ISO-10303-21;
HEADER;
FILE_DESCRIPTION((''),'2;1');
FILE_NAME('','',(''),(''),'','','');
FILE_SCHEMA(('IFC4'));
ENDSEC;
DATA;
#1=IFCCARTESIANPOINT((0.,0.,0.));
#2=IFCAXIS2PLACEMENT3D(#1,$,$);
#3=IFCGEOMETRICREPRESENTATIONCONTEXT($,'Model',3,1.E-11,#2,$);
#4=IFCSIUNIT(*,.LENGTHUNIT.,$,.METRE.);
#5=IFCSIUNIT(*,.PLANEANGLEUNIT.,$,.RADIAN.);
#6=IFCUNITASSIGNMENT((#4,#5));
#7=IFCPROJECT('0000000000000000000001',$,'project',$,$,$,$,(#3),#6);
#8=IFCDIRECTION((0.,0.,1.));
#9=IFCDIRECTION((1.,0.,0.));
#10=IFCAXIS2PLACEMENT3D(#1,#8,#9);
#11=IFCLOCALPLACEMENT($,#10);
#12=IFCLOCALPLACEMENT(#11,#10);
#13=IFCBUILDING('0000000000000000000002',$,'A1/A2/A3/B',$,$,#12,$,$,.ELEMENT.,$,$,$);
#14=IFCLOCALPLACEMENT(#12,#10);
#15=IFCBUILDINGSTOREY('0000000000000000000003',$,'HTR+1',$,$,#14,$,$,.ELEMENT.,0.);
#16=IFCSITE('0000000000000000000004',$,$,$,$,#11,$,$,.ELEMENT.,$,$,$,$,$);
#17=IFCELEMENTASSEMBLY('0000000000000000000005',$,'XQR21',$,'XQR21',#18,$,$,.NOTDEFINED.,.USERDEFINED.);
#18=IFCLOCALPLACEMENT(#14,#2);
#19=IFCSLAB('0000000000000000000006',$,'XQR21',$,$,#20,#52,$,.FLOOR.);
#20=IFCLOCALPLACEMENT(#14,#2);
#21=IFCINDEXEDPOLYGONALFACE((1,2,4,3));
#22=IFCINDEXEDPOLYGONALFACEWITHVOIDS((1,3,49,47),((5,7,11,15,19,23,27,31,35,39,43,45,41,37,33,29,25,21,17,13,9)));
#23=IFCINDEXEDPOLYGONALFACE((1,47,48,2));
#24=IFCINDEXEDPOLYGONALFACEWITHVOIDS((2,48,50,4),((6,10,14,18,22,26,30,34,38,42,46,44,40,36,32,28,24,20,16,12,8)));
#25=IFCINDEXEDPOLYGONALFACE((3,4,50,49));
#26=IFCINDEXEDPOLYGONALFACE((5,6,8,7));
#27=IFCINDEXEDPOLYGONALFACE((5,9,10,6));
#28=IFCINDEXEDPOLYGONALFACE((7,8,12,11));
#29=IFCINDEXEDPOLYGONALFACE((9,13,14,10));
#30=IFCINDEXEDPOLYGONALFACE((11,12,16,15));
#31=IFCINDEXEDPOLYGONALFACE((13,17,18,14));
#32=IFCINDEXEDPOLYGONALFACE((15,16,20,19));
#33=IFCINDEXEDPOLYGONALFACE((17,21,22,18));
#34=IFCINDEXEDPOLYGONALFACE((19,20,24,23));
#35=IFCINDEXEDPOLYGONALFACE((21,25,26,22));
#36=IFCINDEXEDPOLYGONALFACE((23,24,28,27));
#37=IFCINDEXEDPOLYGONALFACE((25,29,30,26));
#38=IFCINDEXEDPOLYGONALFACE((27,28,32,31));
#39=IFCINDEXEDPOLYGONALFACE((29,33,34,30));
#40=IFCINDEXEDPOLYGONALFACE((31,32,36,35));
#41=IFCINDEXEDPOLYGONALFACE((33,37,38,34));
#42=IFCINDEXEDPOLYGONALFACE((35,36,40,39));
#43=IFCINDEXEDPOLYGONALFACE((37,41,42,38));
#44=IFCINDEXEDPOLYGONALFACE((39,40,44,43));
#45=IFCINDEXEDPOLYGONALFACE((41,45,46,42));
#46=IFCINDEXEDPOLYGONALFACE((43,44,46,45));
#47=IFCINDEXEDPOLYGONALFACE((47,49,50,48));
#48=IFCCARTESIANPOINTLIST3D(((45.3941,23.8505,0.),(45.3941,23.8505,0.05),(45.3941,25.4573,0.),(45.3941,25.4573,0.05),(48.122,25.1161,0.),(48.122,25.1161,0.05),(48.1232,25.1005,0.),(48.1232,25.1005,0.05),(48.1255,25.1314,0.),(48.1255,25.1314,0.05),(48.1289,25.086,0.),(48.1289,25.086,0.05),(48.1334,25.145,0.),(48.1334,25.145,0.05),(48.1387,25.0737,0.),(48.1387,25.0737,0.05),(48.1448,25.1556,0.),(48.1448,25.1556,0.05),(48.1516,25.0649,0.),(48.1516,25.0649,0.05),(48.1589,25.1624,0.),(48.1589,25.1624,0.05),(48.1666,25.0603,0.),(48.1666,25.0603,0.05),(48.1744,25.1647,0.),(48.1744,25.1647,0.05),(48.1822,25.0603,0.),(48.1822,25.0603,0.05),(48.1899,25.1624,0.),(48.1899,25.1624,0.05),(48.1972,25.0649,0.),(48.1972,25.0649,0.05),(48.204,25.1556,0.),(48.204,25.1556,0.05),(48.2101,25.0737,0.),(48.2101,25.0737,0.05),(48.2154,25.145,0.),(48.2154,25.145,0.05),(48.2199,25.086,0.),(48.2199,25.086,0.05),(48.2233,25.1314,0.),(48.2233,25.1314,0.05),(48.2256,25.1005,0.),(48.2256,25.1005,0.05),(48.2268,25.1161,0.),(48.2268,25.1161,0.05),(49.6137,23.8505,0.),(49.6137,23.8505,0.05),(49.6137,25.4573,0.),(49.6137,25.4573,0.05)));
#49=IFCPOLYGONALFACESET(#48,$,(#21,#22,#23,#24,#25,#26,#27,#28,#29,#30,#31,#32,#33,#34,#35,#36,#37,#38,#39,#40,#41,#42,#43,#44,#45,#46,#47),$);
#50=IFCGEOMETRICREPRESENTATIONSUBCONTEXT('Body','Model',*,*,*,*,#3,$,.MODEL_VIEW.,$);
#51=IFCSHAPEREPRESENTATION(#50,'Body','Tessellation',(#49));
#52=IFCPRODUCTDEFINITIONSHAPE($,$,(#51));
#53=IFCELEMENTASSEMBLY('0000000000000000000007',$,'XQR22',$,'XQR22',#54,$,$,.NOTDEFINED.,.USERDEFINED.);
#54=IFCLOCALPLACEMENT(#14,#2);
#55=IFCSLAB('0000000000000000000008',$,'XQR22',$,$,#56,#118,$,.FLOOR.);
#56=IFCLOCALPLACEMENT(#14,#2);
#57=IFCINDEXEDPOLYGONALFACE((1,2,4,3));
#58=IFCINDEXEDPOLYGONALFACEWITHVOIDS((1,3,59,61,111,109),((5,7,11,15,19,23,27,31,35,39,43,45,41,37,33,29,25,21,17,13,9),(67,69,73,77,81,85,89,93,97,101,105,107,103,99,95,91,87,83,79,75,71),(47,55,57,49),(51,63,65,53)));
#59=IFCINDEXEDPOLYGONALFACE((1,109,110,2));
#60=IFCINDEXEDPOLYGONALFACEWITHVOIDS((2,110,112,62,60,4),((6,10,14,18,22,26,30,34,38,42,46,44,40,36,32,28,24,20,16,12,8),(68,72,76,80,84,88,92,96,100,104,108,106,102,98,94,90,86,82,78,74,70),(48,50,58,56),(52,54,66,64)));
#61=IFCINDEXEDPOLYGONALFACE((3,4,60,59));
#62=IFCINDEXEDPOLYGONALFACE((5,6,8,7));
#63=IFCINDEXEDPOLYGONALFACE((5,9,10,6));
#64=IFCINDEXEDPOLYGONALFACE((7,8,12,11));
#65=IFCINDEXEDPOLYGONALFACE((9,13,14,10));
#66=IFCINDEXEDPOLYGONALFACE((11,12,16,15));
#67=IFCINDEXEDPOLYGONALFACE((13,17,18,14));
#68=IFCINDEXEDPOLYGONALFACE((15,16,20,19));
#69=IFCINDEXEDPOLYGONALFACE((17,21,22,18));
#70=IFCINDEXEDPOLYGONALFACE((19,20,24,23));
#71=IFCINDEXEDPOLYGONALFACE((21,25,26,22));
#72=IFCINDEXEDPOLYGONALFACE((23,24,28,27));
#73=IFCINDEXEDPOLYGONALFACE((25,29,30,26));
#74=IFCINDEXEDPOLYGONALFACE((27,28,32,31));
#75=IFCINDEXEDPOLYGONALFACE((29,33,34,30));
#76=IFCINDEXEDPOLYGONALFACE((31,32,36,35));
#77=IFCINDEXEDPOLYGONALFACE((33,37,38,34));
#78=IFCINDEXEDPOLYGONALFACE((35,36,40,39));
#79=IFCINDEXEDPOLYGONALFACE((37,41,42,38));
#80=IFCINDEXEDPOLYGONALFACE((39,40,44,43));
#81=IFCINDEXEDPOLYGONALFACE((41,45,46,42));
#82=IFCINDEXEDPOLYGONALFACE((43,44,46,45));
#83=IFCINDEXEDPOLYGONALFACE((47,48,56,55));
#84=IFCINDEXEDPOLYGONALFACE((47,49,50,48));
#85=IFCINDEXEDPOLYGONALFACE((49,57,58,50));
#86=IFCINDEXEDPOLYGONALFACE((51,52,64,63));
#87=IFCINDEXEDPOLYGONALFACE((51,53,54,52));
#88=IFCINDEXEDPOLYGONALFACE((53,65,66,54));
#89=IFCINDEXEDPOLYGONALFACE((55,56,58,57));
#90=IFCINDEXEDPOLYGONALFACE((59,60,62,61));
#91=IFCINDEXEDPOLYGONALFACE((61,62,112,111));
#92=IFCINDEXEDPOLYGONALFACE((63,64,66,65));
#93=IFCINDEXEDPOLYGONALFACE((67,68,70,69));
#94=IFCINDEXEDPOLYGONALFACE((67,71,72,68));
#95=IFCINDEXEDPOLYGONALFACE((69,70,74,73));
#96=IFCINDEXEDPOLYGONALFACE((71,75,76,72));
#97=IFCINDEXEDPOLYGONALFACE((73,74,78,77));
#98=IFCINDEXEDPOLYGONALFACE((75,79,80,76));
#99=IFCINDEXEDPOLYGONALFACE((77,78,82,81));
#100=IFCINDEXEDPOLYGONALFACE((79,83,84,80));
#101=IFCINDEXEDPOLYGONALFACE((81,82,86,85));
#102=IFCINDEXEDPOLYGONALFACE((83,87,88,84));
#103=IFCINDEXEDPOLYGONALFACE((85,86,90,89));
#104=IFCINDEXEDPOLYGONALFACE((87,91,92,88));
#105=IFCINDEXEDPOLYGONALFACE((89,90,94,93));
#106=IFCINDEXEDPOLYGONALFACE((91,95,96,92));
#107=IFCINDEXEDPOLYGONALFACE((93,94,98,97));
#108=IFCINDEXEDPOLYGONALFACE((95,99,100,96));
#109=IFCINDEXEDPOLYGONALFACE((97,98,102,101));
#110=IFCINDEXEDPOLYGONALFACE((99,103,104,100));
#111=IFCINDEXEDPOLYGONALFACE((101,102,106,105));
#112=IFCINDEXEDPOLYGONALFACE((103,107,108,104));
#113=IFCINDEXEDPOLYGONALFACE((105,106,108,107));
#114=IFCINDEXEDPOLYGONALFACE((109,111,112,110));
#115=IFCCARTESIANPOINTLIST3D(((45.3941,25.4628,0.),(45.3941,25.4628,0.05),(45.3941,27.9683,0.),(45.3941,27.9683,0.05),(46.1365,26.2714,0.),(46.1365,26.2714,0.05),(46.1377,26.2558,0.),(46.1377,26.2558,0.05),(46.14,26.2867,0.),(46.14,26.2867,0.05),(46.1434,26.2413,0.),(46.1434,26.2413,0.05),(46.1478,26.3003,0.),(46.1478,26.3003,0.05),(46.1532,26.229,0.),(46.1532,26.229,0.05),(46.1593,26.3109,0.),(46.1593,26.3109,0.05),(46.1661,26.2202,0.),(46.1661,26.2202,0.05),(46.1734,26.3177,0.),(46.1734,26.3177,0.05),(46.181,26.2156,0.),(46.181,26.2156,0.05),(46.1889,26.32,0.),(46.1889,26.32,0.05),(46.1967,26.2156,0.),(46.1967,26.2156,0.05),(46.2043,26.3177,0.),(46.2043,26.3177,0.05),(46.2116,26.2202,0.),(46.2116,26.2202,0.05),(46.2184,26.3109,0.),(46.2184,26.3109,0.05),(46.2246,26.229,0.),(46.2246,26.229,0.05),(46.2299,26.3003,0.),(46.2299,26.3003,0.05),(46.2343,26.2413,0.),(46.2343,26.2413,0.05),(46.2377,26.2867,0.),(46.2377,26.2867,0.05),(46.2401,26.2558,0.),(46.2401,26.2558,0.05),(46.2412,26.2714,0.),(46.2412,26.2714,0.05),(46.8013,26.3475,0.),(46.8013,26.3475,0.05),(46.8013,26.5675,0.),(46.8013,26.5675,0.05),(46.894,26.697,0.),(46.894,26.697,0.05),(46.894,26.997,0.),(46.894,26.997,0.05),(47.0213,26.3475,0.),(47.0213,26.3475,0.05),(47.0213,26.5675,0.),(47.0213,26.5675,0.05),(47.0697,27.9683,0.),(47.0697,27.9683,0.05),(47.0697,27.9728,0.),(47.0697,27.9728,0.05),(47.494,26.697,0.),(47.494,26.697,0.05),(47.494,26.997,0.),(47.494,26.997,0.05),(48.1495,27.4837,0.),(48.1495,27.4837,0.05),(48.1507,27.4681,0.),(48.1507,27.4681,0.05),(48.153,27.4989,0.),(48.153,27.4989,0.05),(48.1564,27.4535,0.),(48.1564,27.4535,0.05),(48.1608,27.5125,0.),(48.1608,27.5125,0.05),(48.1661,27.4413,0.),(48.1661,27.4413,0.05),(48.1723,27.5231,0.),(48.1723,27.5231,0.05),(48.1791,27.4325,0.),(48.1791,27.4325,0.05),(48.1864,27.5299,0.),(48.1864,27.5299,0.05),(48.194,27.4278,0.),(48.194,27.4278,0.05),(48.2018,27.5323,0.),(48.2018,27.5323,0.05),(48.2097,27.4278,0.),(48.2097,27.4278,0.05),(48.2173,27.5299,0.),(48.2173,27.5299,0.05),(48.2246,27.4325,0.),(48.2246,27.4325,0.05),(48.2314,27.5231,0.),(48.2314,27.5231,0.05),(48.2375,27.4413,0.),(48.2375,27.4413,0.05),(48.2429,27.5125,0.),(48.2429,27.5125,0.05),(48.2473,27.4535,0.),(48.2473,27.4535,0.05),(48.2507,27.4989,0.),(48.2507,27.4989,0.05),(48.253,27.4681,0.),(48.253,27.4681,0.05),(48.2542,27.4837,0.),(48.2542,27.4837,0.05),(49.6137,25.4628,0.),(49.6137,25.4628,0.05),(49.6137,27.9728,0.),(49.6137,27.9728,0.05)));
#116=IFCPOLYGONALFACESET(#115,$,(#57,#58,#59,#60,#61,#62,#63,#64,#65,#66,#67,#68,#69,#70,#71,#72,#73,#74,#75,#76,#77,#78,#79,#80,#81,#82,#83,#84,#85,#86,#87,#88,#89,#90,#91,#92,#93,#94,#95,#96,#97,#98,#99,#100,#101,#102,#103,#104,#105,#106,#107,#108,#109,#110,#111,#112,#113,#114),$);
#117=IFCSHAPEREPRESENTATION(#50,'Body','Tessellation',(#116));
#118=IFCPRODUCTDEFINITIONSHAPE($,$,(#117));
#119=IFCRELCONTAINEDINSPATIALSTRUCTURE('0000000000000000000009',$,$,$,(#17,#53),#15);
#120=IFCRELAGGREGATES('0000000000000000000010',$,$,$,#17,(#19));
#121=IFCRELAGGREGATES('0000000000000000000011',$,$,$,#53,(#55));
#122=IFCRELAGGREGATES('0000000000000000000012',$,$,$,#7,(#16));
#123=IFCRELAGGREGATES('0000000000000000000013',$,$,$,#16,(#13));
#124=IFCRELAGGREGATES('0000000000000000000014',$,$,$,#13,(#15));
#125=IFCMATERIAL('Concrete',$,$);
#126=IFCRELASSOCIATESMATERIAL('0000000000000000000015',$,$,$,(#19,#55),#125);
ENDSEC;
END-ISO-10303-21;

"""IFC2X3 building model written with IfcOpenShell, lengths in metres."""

from ifc_helpers import new_model, si_unit, frame, origin, origin_with_axes, origin_2d_with_axis, place, context, subcontext, project, spatial, polyline, circle, outline, extrude, material, element, aggregate, save


model = new_model("IFC2X3")

# Units and contexts
model_context = context("Model", 3, precision=1e-11, world=origin())
body_context = subcontext(model_context, "Body", "Model", "MODEL_VIEW")
ifc_project = project(units=[si_unit("LENGTHUNIT", "METRE"), si_unit("PLANEANGLEUNIT", "RADIAN")], contexts=[model_context])

# Site, building, storey
site_placement = place(None, origin_with_axes())
site = spatial("IfcSite", under=ifc_project, at=site_placement, CompositionType="ELEMENT")
building_placement = place(site_placement, origin_with_axes())
building = spatial("IfcBuilding", under=site, at=building_placement, Name="A1/A2/A3/B", CompositionType="ELEMENT")
storey_placement = place(building_placement, origin_with_axes())
storey = spatial("IfcBuildingStorey", under=building, at=storey_placement, Name="HTR+1", CompositionType="ELEMENT", Elevation=0.0)

# Element assembly, slab, opening
assembly_1_placement = place(storey_placement, origin_with_axes())
assembly_1 = element("IfcElementAssembly", 1, at=assembly_1_placement, inside=storey, Name="XQR21", ObjectType="XQR21", AssemblyPlace="NOTDEFINED", PredefinedType="USERDEFINED")
ifc_material = material(Name="Concrete")
slab_1_placement = place(assembly_1_placement, frame((45.3941, 23.8505, 0.0), z_axis=(0.0, 0.0, 1.0), x_axis=(1.0, 0.0, 0.0)))
slab_1 = element("IfcSlab", 2, at=slab_1_placement, material=ifc_material, Name="XQR21", PredefinedType="FLOOR", context=body_context, shape_type="SweptSolid", body=[
    extrude(outline(polyline([(0.0, 0.0), (0.0, -4.2197), (1.6068, -4.2197), (1.6068, 0.0), (0.0, 0.0)])), frame((0.0, 0.0, 0.0), z_axis=(0.0, 0.0, 1.0), x_axis=(0.0, 1.0, 0.0)), (0.0, 0.0, 1.0), 0.05),
])
opening_1_placement = place(slab_1_placement, frame((2.7803, 1.2617, 0.0), z_axis=(0.0, 0.0, 1.0), x_axis=(1.0, 0.0, 0.0)))
element("IfcOpeningElement", 3, at=opening_1_placement, cuts=slab_1, ObjectType="Opening", context=body_context, shape_type="SweptSolid", body=[
    extrude(circle(Radius=0.0525, at=origin_2d_with_axis()), frame((0.0, 0.0, 0.0), z_axis=(0.0, 0.0, 1.0), x_axis=(0.0, 1.0, 0.0)), (0.0, 0.0, 1.0), 0.05),
])

# Element assembly, slab, openings
assembly_2_placement = place(storey_placement, origin_with_axes())
assembly_2 = element("IfcElementAssembly", 4, at=assembly_2_placement, inside=storey, Name="XQR22", ObjectType="XQR22", AssemblyPlace="NOTDEFINED", PredefinedType="USERDEFINED")
slab_2_placement = place(assembly_2_placement, frame((45.3941, 25.4628, 0.0), z_axis=(0.0, 0.0, 1.0), x_axis=(1.0, 0.0, 0.0)))
slab_2 = element("IfcSlab", 5, at=slab_2_placement, material=ifc_material, Name="XQR22", PredefinedType="FLOOR", context=body_context, shape_type="SweptSolid", body=[
    extrude(outline(polyline([(0.0, 0.0), (0.0, -4.2197), (2.51, -4.2197), (2.51, -1.6757), (2.5055, -1.6757), (2.5055, 0.0), (0.0, 0.0)])), frame((0.0, 0.0, 0.0), z_axis=(0.0, 0.0, 1.0), x_axis=(0.0, 1.0, 0.0)), (0.0, 0.0, 1.0), 0.05),
])
opening_2_placement = place(slab_2_placement, origin_with_axes())
element("IfcOpeningElement", 6, at=opening_2_placement, cuts=slab_2, ObjectType="Opening", context=body_context, shape_type="SweptSolid", body=[
    extrude(outline(polyline([(1.2342, -1.4999), (1.2342, -2.0999), (1.5342, -2.0999), (1.5342, -1.4999), (1.2342, -1.4999)])), frame((0.0, 0.0, 0.0), z_axis=(0.0, 0.0, 1.0), x_axis=(0.0, 1.0, 0.0)), (0.0, 0.0, 1.0), 0.05),
])
opening_3_placement = place(slab_2_placement, origin_with_axes())
element("IfcOpeningElement", 7, at=opening_3_placement, cuts=slab_2, ObjectType="Opening", context=body_context, shape_type="SweptSolid", body=[
    extrude(outline(polyline([(0.8848, -1.4072), (0.8848, -1.6272), (1.1048, -1.6272), (1.1048, -1.4072), (0.8848, -1.4072)])), frame((0.0, 0.0, 0.0), z_axis=(0.0, 0.0, 1.0), x_axis=(0.0, 1.0, 0.0)), (0.0, 0.0, 1.0), 0.05),
])
opening_4_placement = place(slab_2_placement, frame((2.8078, 2.017, 0.0), z_axis=(0.0, 0.0, 1.0), x_axis=(1.0, 0.0, 0.0)))
element("IfcOpeningElement", 8, at=opening_4_placement, cuts=slab_2, ObjectType="Opening", context=body_context, shape_type="SweptSolid", body=[
    extrude(circle(Radius=0.0525, at=origin_2d_with_axis()), frame((0.0, 0.0, 0.0), z_axis=(0.0, 0.0, 1.0), x_axis=(0.0, 1.0, 0.0)), (0.0, 0.0, 1.0), 0.05),
])
opening_5_placement = place(slab_2_placement, frame((0.7948, 0.8047, 0.0), z_axis=(0.0, 0.0, 1.0), x_axis=(1.0, 0.0, 0.0)))
element("IfcOpeningElement", 9, at=opening_5_placement, cuts=slab_2, ObjectType="Opening", context=body_context, shape_type="SweptSolid", body=[
    extrude(circle(Radius=0.0525, at=origin_2d_with_axis()), frame((0.0, 0.0, 0.0), z_axis=(0.0, 0.0, 1.0), x_axis=(0.0, 1.0, 0.0)), (0.0, 0.0, 1.0), 0.05),
])

aggregate(assembly_1, [slab_1])
aggregate(assembly_2, [slab_2])

save(model, "model.ifc")
